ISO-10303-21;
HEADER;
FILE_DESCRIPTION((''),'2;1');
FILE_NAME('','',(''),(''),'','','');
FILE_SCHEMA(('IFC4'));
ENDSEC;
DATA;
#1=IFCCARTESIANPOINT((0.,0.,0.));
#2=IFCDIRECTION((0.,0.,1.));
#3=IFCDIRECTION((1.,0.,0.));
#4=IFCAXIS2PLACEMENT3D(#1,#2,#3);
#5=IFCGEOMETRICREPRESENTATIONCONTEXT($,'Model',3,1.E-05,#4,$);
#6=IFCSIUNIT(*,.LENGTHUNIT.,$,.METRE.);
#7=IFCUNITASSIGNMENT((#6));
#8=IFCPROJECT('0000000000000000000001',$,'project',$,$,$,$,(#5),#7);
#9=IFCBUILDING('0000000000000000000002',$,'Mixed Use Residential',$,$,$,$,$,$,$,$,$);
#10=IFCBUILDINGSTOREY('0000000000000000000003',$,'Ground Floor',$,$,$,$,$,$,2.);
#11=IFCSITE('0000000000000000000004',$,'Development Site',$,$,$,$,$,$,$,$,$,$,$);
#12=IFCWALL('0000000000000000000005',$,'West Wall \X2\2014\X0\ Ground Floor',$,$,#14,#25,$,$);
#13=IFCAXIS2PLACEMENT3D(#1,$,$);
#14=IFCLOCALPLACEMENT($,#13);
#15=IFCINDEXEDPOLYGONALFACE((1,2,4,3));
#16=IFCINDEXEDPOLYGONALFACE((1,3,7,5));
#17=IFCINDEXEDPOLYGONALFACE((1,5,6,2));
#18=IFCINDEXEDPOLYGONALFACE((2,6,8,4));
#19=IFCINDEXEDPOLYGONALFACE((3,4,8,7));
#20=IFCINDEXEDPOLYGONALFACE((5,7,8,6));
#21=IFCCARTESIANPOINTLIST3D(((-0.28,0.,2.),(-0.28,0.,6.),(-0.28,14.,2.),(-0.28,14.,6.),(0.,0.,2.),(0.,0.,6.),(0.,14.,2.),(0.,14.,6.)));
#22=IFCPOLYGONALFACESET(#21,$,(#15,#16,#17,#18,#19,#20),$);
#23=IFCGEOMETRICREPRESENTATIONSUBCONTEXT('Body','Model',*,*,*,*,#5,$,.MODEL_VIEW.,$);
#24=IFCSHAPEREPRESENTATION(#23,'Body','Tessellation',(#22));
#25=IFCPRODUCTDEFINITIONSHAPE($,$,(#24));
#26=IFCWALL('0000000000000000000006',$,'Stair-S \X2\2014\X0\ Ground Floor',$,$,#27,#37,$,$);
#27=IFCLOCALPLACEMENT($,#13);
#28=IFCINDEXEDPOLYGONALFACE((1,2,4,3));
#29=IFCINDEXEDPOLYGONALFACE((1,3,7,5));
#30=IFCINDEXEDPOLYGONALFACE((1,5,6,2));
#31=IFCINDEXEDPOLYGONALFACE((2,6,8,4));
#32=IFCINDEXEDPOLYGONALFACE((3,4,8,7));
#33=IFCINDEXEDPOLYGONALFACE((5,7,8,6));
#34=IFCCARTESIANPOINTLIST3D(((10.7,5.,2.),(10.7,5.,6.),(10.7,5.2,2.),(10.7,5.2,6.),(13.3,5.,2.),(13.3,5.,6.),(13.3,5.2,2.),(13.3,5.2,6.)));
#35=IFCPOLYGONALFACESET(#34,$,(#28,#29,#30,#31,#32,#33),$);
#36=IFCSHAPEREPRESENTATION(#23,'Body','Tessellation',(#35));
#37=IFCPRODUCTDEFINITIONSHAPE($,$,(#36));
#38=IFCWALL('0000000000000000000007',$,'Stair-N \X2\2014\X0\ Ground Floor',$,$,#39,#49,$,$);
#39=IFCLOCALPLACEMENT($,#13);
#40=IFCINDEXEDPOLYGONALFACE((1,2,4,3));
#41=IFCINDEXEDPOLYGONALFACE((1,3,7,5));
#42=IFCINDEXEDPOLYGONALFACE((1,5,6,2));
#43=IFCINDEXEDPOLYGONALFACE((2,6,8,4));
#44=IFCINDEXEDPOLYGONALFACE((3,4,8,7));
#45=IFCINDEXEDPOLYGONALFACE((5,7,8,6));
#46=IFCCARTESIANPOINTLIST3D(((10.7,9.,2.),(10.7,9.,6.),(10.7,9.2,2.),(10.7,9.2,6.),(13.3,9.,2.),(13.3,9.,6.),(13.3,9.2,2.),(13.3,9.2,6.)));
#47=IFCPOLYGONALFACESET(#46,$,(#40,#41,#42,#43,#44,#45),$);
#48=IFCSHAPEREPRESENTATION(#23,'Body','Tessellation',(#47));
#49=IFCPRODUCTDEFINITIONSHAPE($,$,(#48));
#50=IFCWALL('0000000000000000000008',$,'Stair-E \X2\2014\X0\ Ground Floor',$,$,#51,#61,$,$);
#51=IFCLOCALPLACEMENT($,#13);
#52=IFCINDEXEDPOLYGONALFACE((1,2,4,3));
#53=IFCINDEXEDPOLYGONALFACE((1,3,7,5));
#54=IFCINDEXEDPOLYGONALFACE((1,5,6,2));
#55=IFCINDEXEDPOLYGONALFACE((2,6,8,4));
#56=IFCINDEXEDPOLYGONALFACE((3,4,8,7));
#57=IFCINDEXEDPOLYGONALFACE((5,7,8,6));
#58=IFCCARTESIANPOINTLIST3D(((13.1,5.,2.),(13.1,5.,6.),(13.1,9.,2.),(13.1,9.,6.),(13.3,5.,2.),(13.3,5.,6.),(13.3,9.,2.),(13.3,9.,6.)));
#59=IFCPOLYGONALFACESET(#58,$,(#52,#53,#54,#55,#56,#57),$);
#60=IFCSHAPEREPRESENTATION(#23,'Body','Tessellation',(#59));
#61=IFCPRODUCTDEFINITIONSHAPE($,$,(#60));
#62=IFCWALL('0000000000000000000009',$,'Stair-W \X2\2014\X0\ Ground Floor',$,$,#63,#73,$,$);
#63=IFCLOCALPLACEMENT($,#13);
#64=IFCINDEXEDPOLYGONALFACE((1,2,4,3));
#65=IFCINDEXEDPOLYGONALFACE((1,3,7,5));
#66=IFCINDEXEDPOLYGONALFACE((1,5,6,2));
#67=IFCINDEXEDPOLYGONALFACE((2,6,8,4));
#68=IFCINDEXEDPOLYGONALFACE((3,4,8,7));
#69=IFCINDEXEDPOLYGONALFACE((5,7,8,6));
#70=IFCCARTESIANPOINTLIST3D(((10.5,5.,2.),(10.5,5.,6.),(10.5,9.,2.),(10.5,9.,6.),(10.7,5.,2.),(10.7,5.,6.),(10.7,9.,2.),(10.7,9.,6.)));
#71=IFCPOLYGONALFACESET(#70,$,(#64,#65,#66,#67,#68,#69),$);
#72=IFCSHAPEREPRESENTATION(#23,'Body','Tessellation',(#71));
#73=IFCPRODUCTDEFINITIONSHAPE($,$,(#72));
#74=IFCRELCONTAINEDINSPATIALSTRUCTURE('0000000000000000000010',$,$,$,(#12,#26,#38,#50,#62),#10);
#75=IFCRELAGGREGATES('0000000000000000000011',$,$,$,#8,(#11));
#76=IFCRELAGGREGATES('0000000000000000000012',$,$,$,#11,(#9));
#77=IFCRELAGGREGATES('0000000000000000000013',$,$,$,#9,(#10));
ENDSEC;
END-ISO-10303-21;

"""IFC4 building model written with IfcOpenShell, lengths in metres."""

from ifc_helpers import new_model, si_unit, frame, origin_with_axes, place, context, subcontext, project, spatial, indexed_curve, outline, extrude, element, save


model = new_model("IFC4")

# Units and contexts
model_context = context("Model", 3, precision=1e-05, world=origin_with_axes())
body_context = subcontext(model_context, "Body", "Model", "MODEL_VIEW")
ifc_project = project(units=[si_unit("LENGTHUNIT", "METRE")], contexts=[model_context])

# Site, building, storey
site = spatial("IfcSite", under=ifc_project, Name="Development Site")
building = spatial("IfcBuilding", under=site, Name="Mixed Use Residential")
storey = spatial("IfcBuildingStorey", under=building, Name="Ground Floor", Elevation=2.0)

# Walls
for number, where, z_axis, x_axis, name in (
    (1, (0.0, 0.0, 2.0), (0.0, 0.0, 1.0), (0.0, 1.0, 0.0), "West Wall — Ground Floor"),
):
    element("IfcWall", number, at=place(None, frame(where, z_axis=z_axis, x_axis=x_axis)), inside=storey, Name=name, context=body_context, shape_type="SweptSolid", body=[
        extrude(outline(indexed_curve([(0.0, 0.0), (0.0, 0.28), (14.0, 0.28), (14.0, 0.0), (0.0, 0.0)], self_intersect=False)), origin_with_axes(), (0.0, 0.0, 1.0), 4.0),
    ])
for number, where, z_axis, x_axis, name in (
    (2, (10.7, 5.0, 2.0), (0.0, 0.0, 1.0), (1.0, 0.0, 0.0), "Stair-S — Ground Floor"),
    (3, (10.7, 9.0, 2.0), (0.0, 0.0, 1.0), (1.0, 0.0, 0.0), "Stair-N — Ground Floor"),
):
    element("IfcWall", number, at=place(None, frame(where, z_axis=z_axis, x_axis=x_axis)), inside=storey, Name=name, context=body_context, shape_type="SweptSolid", body=[
        extrude(outline(indexed_curve([(0.0, 0.0), (0.0, 0.2), (2.6, 0.2), (2.6, 0.0), (0.0, 0.0)], self_intersect=False)), origin_with_axes(), (0.0, 0.0, 1.0), 4.0),
    ])
for number, where, z_axis, x_axis, name in (
    (4, (13.3, 5.0, 2.0), (0.0, 0.0, 1.0), (0.0, 1.0, 0.0), "Stair-E — Ground Floor"),
    (5, (10.7, 5.0, 2.0), (0.0, 0.0, 1.0), (0.0, 1.0, 0.0), "Stair-W — Ground Floor"),
):
    element("IfcWall", number, at=place(None, frame(where, z_axis=z_axis, x_axis=x_axis)), inside=storey, Name=name, context=body_context, shape_type="SweptSolid", body=[
        extrude(outline(indexed_curve([(0.0, 0.0), (0.0, 0.2), (4.0, 0.2), (4.0, 0.0), (0.0, 0.0)], self_intersect=False)), origin_with_axes(), (0.0, 0.0, 1.0), 4.0),
    ])

save(model, "model.ifc")
